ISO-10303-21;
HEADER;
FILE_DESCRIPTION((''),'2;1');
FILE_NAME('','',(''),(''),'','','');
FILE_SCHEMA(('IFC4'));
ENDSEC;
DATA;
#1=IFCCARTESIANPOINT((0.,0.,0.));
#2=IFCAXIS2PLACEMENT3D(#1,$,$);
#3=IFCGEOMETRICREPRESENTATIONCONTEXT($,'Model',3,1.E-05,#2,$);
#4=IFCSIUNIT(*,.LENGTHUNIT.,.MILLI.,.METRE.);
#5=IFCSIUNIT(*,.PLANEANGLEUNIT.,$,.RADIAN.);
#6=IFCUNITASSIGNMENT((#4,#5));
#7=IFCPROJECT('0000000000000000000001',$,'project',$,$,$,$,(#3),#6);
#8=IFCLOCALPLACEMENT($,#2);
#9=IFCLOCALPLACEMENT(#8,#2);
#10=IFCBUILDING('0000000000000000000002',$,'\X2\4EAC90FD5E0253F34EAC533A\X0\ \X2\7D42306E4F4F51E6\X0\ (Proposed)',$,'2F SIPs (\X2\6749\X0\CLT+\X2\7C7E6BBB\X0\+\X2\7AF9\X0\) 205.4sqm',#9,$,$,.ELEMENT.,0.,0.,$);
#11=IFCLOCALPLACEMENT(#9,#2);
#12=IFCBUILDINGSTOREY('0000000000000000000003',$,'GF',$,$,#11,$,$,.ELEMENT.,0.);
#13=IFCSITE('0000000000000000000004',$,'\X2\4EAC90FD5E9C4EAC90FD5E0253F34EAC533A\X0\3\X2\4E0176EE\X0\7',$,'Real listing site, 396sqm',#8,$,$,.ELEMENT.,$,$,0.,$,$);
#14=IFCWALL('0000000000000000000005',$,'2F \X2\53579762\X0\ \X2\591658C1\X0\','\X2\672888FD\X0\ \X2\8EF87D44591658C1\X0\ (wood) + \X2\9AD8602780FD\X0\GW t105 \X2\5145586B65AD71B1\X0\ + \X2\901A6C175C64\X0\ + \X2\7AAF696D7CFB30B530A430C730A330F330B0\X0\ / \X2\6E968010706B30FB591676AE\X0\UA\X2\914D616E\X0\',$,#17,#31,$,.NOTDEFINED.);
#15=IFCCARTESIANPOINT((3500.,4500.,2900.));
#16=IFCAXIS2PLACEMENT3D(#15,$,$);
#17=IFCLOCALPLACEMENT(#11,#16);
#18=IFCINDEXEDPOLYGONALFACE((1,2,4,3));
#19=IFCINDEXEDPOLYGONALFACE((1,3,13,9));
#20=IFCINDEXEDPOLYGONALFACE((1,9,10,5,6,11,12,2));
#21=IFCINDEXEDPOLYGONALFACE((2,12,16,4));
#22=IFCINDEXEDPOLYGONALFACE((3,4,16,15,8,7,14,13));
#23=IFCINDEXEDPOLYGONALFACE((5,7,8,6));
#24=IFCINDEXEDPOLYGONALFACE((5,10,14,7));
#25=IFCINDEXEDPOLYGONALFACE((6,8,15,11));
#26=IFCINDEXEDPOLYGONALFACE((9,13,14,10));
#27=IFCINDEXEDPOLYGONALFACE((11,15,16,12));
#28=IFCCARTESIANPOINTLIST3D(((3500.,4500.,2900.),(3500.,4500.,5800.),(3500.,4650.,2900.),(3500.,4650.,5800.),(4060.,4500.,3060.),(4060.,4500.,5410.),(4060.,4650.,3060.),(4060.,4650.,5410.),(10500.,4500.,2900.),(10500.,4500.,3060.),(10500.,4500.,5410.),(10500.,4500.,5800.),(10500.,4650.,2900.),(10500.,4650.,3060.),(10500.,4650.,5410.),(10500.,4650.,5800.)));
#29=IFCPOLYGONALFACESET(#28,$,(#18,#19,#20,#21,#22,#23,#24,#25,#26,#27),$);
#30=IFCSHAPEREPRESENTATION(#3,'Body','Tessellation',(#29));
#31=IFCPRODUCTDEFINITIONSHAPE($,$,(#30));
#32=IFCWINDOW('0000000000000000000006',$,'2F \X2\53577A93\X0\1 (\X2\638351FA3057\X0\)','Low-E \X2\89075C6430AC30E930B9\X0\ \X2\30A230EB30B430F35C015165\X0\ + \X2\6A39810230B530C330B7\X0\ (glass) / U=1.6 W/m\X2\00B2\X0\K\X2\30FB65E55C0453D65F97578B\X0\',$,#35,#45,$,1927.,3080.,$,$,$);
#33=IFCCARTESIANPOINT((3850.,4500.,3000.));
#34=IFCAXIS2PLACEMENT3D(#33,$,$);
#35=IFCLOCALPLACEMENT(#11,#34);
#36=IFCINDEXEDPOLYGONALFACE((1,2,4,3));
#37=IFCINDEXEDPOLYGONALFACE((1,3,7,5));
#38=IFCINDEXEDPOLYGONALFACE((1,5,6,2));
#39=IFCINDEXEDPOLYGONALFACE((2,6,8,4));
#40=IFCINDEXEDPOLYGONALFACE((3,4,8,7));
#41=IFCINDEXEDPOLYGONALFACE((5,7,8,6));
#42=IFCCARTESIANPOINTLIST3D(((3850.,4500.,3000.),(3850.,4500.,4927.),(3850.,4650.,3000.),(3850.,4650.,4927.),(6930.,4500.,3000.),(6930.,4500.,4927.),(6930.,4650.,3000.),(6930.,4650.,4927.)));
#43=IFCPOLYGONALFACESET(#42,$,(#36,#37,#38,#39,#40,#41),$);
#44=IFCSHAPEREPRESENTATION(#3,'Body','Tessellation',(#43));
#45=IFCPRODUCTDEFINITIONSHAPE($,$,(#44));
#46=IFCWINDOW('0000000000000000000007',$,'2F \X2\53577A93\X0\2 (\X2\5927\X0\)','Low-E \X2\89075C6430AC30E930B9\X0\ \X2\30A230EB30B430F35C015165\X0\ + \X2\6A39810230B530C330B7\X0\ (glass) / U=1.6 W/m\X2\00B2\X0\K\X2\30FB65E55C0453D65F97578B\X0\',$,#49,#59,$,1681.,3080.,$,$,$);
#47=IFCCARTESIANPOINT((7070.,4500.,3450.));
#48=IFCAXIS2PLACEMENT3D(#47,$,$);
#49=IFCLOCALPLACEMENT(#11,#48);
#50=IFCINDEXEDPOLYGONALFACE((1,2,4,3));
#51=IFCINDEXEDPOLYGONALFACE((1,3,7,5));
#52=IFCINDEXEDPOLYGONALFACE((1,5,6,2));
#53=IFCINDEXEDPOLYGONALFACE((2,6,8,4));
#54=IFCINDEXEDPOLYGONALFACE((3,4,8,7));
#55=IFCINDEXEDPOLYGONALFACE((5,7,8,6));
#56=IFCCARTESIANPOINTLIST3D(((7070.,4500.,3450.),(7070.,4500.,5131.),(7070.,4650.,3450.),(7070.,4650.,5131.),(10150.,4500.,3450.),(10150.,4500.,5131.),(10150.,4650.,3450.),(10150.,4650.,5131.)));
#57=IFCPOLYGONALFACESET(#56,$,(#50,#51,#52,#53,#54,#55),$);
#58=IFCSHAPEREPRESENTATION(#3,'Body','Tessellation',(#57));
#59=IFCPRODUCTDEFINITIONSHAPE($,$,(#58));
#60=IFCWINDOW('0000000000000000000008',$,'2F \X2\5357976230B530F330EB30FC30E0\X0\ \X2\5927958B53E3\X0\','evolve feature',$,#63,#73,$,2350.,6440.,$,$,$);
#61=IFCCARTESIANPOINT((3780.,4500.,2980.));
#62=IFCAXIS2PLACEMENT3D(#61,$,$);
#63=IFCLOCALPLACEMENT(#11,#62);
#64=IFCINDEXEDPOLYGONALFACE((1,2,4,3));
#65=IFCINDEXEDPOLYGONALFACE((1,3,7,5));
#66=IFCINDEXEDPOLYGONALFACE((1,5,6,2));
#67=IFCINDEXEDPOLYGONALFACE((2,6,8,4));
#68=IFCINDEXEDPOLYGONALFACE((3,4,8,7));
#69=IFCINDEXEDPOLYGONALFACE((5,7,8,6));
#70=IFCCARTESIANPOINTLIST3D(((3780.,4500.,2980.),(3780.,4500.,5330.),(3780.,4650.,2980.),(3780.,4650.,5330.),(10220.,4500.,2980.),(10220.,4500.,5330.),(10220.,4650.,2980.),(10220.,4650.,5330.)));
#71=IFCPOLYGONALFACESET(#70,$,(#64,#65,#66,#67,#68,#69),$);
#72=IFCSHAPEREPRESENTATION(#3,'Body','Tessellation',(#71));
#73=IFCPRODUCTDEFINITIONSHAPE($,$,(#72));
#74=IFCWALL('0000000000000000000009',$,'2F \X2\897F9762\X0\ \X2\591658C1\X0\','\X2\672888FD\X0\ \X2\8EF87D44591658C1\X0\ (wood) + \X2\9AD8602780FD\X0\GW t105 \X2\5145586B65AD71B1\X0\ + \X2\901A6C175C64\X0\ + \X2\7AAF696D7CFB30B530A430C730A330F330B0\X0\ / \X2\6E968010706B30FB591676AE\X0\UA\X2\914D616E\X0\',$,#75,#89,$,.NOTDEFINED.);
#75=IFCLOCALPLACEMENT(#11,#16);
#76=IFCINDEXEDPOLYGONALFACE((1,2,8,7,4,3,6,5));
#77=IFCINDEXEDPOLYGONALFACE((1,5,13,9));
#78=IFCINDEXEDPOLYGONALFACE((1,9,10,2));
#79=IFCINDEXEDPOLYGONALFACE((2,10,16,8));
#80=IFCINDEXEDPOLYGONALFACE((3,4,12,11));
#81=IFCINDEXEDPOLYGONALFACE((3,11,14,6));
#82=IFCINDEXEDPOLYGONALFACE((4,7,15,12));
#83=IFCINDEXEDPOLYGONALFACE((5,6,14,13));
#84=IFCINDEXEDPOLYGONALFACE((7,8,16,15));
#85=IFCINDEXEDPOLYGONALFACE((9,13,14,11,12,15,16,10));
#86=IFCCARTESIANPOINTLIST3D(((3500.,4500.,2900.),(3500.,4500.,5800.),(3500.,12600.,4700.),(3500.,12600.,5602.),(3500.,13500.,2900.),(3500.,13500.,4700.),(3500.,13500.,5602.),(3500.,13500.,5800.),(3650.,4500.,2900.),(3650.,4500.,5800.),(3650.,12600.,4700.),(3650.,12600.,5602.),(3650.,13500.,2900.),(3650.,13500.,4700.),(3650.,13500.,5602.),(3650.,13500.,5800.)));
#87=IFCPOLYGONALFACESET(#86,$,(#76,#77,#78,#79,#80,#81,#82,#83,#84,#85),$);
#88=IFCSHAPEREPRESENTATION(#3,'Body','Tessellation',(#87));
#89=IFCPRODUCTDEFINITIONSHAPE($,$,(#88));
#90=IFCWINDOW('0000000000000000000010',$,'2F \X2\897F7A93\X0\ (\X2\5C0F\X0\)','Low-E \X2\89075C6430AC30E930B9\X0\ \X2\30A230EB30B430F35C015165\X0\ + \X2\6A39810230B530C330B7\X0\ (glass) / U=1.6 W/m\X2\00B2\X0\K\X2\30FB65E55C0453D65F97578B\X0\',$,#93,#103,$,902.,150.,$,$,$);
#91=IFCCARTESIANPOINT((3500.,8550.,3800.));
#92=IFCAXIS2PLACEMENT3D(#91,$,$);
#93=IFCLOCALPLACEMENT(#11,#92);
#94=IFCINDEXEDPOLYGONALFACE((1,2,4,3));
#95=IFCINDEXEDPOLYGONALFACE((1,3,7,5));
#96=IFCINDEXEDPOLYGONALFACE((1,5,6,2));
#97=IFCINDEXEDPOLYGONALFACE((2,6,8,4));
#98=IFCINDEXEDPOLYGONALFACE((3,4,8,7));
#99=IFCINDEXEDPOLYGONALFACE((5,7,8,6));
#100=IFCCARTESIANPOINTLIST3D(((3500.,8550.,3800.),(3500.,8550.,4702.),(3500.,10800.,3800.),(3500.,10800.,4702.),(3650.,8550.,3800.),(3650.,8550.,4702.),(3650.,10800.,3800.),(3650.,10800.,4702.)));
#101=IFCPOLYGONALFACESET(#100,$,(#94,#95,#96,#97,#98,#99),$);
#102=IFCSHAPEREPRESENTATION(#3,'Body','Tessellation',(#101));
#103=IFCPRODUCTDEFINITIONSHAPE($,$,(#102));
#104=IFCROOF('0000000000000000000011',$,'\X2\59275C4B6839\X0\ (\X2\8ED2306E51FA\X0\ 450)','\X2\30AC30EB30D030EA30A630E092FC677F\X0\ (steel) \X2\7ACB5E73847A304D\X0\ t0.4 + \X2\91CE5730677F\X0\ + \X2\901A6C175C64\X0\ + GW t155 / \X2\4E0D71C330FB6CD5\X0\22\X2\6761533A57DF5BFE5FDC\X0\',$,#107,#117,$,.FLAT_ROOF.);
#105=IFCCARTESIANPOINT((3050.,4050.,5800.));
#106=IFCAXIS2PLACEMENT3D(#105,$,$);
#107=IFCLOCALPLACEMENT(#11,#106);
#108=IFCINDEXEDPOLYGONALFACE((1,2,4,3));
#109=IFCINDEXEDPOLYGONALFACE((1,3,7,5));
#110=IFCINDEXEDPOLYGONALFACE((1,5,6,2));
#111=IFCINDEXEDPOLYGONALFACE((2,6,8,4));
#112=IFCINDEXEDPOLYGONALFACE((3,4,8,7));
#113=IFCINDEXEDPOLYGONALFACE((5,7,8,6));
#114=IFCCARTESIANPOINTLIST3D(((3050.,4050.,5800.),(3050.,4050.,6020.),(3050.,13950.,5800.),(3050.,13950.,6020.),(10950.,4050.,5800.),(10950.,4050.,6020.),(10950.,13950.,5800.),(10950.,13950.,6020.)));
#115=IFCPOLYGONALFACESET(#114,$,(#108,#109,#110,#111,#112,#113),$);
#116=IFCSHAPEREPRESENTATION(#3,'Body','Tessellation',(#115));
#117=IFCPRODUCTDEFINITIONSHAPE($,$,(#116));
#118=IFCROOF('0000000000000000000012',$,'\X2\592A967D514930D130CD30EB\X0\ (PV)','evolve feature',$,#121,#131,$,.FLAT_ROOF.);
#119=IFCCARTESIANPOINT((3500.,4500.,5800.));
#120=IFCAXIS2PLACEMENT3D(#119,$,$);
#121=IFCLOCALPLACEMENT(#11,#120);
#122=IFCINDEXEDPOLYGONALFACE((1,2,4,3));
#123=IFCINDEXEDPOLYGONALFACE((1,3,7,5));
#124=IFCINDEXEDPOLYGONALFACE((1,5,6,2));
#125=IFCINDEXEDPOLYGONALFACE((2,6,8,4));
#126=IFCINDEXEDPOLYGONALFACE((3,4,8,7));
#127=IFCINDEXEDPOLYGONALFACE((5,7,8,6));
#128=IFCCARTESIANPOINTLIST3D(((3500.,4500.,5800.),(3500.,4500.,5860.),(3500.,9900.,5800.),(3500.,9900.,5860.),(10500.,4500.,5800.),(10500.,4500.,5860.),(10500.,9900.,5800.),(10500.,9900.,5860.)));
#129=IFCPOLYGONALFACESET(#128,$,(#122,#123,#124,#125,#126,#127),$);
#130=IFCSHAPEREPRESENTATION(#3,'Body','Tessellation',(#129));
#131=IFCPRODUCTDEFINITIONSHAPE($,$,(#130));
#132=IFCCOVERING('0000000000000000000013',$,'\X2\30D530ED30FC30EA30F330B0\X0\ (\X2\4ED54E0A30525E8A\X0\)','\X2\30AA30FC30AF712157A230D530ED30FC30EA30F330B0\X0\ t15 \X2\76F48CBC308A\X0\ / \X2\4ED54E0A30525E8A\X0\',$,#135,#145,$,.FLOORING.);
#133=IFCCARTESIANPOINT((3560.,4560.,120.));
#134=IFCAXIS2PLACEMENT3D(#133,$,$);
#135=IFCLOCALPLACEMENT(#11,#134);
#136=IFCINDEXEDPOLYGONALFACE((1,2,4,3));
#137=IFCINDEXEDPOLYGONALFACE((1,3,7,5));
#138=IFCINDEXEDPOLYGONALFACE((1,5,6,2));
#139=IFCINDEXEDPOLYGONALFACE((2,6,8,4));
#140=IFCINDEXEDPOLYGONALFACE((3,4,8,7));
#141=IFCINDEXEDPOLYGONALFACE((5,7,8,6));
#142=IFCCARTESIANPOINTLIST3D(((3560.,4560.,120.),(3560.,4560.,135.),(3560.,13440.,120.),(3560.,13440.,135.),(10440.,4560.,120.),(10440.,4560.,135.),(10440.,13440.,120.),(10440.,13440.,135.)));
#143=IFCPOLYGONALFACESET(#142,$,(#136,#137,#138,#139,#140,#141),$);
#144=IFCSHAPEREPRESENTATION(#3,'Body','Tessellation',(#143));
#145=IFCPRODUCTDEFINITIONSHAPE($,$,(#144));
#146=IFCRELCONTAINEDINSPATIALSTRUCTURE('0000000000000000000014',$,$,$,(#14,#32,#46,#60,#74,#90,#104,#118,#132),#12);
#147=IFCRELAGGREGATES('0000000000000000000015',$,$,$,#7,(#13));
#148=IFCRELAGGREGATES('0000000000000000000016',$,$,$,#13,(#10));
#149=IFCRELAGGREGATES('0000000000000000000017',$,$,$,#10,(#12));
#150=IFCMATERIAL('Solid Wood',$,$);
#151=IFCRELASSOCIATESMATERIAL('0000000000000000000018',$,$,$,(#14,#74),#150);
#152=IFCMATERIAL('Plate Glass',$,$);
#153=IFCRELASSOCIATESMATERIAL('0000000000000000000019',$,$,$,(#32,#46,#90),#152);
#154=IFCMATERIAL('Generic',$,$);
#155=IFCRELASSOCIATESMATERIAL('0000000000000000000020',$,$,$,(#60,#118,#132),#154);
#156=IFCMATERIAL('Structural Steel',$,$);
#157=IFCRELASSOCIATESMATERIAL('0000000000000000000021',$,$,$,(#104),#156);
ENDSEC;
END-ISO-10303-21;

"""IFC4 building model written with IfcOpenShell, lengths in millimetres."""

from ifc_helpers import new_model, si_unit, frame, frame_2d, origin, place, context, project, spatial, rectangle, extrude, material, element, fill, save


model = new_model("IFC4")

# Units and contexts
model_context = context("Model", 3, precision=1e-05, world=origin())
ifc_project = project(units=[si_unit("LENGTHUNIT", "METRE", prefix="MILLI"), si_unit("PLANEANGLEUNIT", "RADIAN")], contexts=[model_context])

# Site, building, storey
site_placement = place(None, origin())
site = spatial("IfcSite", under=ifc_project, at=site_placement, Name="京都府京都市右京区3丁目7", ObjectType="Real listing site, 396sqm", CompositionType="ELEMENT", RefElevation=0.0)
building_placement = place(site_placement, origin())
building = spatial("IfcBuilding", under=site, at=building_placement, Name="京都市右京区 終の住処 (Proposed)", ObjectType="2F SIPs (杉CLT+籾殻+竹) 205.4sqm", CompositionType="ELEMENT", ElevationOfRefHeight=0.0, ElevationOfTerrain=0.0)
storey_placement = place(building_placement, origin())
storey = spatial("IfcBuildingStorey", under=building, at=storey_placement, Name="GF", CompositionType="ELEMENT", Elevation=0.0)

# Shared definitions
ifc_material_1 = material(Name="Solid Wood")
ifc_material_2 = material(Name="Generic")

# Shared definitions
ifc_material_3 = material(Name="Plate Glass")

# Wall, openings, windows
wall_1_placement = place(storey_placement, frame((3500.0, 4500.0, 2900.0)))
wall_1 = element("IfcWall", 1, at=wall_1_placement, inside=storey, material=ifc_material_1, Name="2F 南面 外壁", Description="木製 軸組外壁 (wood) + 高性能GW t105 充填断熱 + 通気層 + 窯業系サイディング / 準耐火・外皮UA配慮", PredefinedType="NOTDEFINED", context=model_context, shape_type="SweptSolid", body=[
    extrude(rectangle(XDim=7000.0, YDim=150.0, at=frame_2d((3500.0, 75.0))), frame((3500.0, 4500.0, 2900.0)), (0.0, 0.0, 1.0), 2900.0),
])
opening_1_placement = place(storey_placement, frame((3850.0, 4500.0, 3000.0)))
opening_1 = element("IfcOpeningElement", 2, at=opening_1_placement, cuts=wall_1, PredefinedType="NOTDEFINED", context=model_context, shape_type="SweptSolid", body=[
    extrude(rectangle(XDim=3080.0, YDim=150.0, at=frame_2d((1540.0, 75.0))), frame((3850.0, 4500.0, 3000.0)), (0.0, 0.0, 1.0), 1927.0),
])
opening_2_placement = place(storey_placement, frame((7070.0, 4500.0, 3450.0)))
opening_2 = element("IfcOpeningElement", 3, at=opening_2_placement, cuts=wall_1, PredefinedType="NOTDEFINED", context=model_context, shape_type="SweptSolid", body=[
    extrude(rectangle(XDim=3080.0, YDim=150.0, at=frame_2d((1540.0, 75.0))), frame((7070.0, 4500.0, 3450.0)), (0.0, 0.0, 1.0), 1681.0),
])
opening_3_placement = place(storey_placement, frame((3780.0, 4500.0, 2980.0)))
opening_3 = element("IfcOpeningElement", 4, at=opening_3_placement, cuts=wall_1, PredefinedType="NOTDEFINED", context=model_context, shape_type="SweptSolid", body=[
    extrude(rectangle(XDim=6440.0, YDim=150.0, at=frame_2d((3220.0, 75.0))), frame((3780.0, 4500.0, 2980.0)), (0.0, 0.0, 1.0), 2350.0),
])
window_1_placement = place(storey_placement, frame((3850.0, 4500.0, 3000.0)))
window_1 = element("IfcWindow", 5, at=window_1_placement, inside=storey, material=ifc_material_3, Name="2F 南窓1 (掃出し)", Description="Low-E 複層ガラス アルゴン封入 + 樹脂サッシ (glass) / U=1.6 W/m²K・日射取得型", OverallHeight=1927.0, OverallWidth=3080.0, context=model_context, shape_type="SweptSolid", body=[
    extrude(rectangle(XDim=3080.0, YDim=150.0, at=frame_2d((1540.0, 75.0))), frame((3850.0, 4500.0, 3000.0)), (0.0, 0.0, 1.0), 1927.0),
])
fill(opening_1, window_1)
window_2_placement = place(storey_placement, frame((7070.0, 4500.0, 3450.0)))
window_2 = element("IfcWindow", 6, at=window_2_placement, inside=storey, material=ifc_material_3, Name="2F 南窓2 (大)", Description="Low-E 複層ガラス アルゴン封入 + 樹脂サッシ (glass) / U=1.6 W/m²K・日射取得型", OverallHeight=1681.0, OverallWidth=3080.0, context=model_context, shape_type="SweptSolid", body=[
    extrude(rectangle(XDim=3080.0, YDim=150.0, at=frame_2d((1540.0, 75.0))), frame((7070.0, 4500.0, 3450.0)), (0.0, 0.0, 1.0), 1681.0),
])
fill(opening_2, window_2)
window_3_placement = place(storey_placement, frame((3780.0, 4500.0, 2980.0)))
window_3 = element("IfcWindow", 7, at=window_3_placement, inside=storey, material=ifc_material_2, Name="2F 南面サンルーム 大開口", Description="evolve feature", OverallHeight=2350.0, OverallWidth=6440.0, context=model_context, shape_type="SweptSolid", body=[
    extrude(rectangle(XDim=6440.0, YDim=150.0, at=frame_2d((3220.0, 75.0))), frame((3780.0, 4500.0, 2980.0)), (0.0, 0.0, 1.0), 2350.0),
])
fill(opening_3, window_3)

# Wall, opening, window
wall_2_placement = place(storey_placement, frame((3500.0, 4500.0, 2900.0)))
wall_2 = element("IfcWall", 8, at=wall_2_placement, inside=storey, material=ifc_material_1, Name="2F 西面 外壁", Description="木製 軸組外壁 (wood) + 高性能GW t105 充填断熱 + 通気層 + 窯業系サイディング / 準耐火・外皮UA配慮", PredefinedType="NOTDEFINED", context=model_context, shape_type="SweptSolid", body=[
    extrude(rectangle(XDim=150.0, YDim=9000.0, at=frame_2d((75.0, 4500.0))), frame((3500.0, 4500.0, 2900.0)), (0.0, 0.0, 1.0), 2900.0),
])
opening_4_placement = place(storey_placement, frame((3500.0, 8550.0, 3800.0)))
opening_4 = element("IfcOpeningElement", 9, at=opening_4_placement, cuts=wall_2, PredefinedType="NOTDEFINED", context=model_context, shape_type="SweptSolid", body=[
    extrude(rectangle(XDim=150.0, YDim=2250.0, at=frame_2d((75.0, 1125.0))), frame((3500.0, 8550.0, 3800.0)), (0.0, 0.0, 1.0), 902.0),
])
window_4_placement = place(storey_placement, frame((3500.0, 8550.0, 3800.0)))
window_4 = element("IfcWindow", 10, at=window_4_placement, inside=storey, material=ifc_material_3, Name="2F 西窓 (小)", Description="Low-E 複層ガラス アルゴン封入 + 樹脂サッシ (glass) / U=1.6 W/m²K・日射取得型", OverallHeight=902.0, OverallWidth=150.0, context=model_context, shape_type="SweptSolid", body=[
    extrude(rectangle(XDim=150.0, YDim=2250.0, at=frame_2d((75.0, 1125.0))), frame((3500.0, 8550.0, 3800.0)), (0.0, 0.0, 1.0), 902.0),
])
fill(opening_4, window_4)

# Roofs
ifc_material_4 = material(Name="Structural Steel")
roof_1_placement = place(storey_placement, frame((3050.0, 4050.0, 5800.0)))
element("IfcRoof", 11, at=roof_1_placement, inside=storey, material=ifc_material_4, Name="大屋根 (軒の出 450)", Description="ガルバリウム鋼板 (steel) 立平葺き t0.4 + 野地板 + 通気層 + GW t155 / 不燃・法22条区域対応", PredefinedType="FLAT_ROOF", context=model_context, shape_type="SweptSolid", body=[
    extrude(rectangle(XDim=7900.0, YDim=9900.0, at=frame_2d((3950.0, 4950.0))), frame((3050.0, 4050.0, 5800.0)), (0.0, 0.0, 1.0), 220.0),
])
roof_2_placement = place(storey_placement, frame((3500.0, 4500.0, 5800.0)))
element("IfcRoof", 12, at=roof_2_placement, inside=storey, material=ifc_material_2, Name="太陽光パネル (PV)", Description="evolve feature", PredefinedType="FLAT_ROOF", context=model_context, shape_type="SweptSolid", body=[
    extrude(rectangle(XDim=7000.0, YDim=5400.0, at=frame_2d((3500.0, 2700.0))), frame((3500.0, 4500.0, 5800.0)), (0.0, 0.0, 1.0), 60.0),
])

# Covering
covering_placement = place(storey_placement, frame((3560.0, 4560.0, 120.0)))
element("IfcCovering", 13, at=covering_placement, inside=storey, material=ifc_material_2, Name="フローリング (仕上げ床)", Description="オーク無垢フローリング t15 直貼り / 仕上げ床", PredefinedType="FLOORING", context=model_context, shape_type="SweptSolid", body=[
    extrude(rectangle(XDim=6880.0, YDim=8880.0, at=frame_2d((3440.0, 4440.0))), frame((3560.0, 4560.0, 120.0)), (0.0, 0.0, 1.0), 15.0),
])

save(model, "model.ifc")
